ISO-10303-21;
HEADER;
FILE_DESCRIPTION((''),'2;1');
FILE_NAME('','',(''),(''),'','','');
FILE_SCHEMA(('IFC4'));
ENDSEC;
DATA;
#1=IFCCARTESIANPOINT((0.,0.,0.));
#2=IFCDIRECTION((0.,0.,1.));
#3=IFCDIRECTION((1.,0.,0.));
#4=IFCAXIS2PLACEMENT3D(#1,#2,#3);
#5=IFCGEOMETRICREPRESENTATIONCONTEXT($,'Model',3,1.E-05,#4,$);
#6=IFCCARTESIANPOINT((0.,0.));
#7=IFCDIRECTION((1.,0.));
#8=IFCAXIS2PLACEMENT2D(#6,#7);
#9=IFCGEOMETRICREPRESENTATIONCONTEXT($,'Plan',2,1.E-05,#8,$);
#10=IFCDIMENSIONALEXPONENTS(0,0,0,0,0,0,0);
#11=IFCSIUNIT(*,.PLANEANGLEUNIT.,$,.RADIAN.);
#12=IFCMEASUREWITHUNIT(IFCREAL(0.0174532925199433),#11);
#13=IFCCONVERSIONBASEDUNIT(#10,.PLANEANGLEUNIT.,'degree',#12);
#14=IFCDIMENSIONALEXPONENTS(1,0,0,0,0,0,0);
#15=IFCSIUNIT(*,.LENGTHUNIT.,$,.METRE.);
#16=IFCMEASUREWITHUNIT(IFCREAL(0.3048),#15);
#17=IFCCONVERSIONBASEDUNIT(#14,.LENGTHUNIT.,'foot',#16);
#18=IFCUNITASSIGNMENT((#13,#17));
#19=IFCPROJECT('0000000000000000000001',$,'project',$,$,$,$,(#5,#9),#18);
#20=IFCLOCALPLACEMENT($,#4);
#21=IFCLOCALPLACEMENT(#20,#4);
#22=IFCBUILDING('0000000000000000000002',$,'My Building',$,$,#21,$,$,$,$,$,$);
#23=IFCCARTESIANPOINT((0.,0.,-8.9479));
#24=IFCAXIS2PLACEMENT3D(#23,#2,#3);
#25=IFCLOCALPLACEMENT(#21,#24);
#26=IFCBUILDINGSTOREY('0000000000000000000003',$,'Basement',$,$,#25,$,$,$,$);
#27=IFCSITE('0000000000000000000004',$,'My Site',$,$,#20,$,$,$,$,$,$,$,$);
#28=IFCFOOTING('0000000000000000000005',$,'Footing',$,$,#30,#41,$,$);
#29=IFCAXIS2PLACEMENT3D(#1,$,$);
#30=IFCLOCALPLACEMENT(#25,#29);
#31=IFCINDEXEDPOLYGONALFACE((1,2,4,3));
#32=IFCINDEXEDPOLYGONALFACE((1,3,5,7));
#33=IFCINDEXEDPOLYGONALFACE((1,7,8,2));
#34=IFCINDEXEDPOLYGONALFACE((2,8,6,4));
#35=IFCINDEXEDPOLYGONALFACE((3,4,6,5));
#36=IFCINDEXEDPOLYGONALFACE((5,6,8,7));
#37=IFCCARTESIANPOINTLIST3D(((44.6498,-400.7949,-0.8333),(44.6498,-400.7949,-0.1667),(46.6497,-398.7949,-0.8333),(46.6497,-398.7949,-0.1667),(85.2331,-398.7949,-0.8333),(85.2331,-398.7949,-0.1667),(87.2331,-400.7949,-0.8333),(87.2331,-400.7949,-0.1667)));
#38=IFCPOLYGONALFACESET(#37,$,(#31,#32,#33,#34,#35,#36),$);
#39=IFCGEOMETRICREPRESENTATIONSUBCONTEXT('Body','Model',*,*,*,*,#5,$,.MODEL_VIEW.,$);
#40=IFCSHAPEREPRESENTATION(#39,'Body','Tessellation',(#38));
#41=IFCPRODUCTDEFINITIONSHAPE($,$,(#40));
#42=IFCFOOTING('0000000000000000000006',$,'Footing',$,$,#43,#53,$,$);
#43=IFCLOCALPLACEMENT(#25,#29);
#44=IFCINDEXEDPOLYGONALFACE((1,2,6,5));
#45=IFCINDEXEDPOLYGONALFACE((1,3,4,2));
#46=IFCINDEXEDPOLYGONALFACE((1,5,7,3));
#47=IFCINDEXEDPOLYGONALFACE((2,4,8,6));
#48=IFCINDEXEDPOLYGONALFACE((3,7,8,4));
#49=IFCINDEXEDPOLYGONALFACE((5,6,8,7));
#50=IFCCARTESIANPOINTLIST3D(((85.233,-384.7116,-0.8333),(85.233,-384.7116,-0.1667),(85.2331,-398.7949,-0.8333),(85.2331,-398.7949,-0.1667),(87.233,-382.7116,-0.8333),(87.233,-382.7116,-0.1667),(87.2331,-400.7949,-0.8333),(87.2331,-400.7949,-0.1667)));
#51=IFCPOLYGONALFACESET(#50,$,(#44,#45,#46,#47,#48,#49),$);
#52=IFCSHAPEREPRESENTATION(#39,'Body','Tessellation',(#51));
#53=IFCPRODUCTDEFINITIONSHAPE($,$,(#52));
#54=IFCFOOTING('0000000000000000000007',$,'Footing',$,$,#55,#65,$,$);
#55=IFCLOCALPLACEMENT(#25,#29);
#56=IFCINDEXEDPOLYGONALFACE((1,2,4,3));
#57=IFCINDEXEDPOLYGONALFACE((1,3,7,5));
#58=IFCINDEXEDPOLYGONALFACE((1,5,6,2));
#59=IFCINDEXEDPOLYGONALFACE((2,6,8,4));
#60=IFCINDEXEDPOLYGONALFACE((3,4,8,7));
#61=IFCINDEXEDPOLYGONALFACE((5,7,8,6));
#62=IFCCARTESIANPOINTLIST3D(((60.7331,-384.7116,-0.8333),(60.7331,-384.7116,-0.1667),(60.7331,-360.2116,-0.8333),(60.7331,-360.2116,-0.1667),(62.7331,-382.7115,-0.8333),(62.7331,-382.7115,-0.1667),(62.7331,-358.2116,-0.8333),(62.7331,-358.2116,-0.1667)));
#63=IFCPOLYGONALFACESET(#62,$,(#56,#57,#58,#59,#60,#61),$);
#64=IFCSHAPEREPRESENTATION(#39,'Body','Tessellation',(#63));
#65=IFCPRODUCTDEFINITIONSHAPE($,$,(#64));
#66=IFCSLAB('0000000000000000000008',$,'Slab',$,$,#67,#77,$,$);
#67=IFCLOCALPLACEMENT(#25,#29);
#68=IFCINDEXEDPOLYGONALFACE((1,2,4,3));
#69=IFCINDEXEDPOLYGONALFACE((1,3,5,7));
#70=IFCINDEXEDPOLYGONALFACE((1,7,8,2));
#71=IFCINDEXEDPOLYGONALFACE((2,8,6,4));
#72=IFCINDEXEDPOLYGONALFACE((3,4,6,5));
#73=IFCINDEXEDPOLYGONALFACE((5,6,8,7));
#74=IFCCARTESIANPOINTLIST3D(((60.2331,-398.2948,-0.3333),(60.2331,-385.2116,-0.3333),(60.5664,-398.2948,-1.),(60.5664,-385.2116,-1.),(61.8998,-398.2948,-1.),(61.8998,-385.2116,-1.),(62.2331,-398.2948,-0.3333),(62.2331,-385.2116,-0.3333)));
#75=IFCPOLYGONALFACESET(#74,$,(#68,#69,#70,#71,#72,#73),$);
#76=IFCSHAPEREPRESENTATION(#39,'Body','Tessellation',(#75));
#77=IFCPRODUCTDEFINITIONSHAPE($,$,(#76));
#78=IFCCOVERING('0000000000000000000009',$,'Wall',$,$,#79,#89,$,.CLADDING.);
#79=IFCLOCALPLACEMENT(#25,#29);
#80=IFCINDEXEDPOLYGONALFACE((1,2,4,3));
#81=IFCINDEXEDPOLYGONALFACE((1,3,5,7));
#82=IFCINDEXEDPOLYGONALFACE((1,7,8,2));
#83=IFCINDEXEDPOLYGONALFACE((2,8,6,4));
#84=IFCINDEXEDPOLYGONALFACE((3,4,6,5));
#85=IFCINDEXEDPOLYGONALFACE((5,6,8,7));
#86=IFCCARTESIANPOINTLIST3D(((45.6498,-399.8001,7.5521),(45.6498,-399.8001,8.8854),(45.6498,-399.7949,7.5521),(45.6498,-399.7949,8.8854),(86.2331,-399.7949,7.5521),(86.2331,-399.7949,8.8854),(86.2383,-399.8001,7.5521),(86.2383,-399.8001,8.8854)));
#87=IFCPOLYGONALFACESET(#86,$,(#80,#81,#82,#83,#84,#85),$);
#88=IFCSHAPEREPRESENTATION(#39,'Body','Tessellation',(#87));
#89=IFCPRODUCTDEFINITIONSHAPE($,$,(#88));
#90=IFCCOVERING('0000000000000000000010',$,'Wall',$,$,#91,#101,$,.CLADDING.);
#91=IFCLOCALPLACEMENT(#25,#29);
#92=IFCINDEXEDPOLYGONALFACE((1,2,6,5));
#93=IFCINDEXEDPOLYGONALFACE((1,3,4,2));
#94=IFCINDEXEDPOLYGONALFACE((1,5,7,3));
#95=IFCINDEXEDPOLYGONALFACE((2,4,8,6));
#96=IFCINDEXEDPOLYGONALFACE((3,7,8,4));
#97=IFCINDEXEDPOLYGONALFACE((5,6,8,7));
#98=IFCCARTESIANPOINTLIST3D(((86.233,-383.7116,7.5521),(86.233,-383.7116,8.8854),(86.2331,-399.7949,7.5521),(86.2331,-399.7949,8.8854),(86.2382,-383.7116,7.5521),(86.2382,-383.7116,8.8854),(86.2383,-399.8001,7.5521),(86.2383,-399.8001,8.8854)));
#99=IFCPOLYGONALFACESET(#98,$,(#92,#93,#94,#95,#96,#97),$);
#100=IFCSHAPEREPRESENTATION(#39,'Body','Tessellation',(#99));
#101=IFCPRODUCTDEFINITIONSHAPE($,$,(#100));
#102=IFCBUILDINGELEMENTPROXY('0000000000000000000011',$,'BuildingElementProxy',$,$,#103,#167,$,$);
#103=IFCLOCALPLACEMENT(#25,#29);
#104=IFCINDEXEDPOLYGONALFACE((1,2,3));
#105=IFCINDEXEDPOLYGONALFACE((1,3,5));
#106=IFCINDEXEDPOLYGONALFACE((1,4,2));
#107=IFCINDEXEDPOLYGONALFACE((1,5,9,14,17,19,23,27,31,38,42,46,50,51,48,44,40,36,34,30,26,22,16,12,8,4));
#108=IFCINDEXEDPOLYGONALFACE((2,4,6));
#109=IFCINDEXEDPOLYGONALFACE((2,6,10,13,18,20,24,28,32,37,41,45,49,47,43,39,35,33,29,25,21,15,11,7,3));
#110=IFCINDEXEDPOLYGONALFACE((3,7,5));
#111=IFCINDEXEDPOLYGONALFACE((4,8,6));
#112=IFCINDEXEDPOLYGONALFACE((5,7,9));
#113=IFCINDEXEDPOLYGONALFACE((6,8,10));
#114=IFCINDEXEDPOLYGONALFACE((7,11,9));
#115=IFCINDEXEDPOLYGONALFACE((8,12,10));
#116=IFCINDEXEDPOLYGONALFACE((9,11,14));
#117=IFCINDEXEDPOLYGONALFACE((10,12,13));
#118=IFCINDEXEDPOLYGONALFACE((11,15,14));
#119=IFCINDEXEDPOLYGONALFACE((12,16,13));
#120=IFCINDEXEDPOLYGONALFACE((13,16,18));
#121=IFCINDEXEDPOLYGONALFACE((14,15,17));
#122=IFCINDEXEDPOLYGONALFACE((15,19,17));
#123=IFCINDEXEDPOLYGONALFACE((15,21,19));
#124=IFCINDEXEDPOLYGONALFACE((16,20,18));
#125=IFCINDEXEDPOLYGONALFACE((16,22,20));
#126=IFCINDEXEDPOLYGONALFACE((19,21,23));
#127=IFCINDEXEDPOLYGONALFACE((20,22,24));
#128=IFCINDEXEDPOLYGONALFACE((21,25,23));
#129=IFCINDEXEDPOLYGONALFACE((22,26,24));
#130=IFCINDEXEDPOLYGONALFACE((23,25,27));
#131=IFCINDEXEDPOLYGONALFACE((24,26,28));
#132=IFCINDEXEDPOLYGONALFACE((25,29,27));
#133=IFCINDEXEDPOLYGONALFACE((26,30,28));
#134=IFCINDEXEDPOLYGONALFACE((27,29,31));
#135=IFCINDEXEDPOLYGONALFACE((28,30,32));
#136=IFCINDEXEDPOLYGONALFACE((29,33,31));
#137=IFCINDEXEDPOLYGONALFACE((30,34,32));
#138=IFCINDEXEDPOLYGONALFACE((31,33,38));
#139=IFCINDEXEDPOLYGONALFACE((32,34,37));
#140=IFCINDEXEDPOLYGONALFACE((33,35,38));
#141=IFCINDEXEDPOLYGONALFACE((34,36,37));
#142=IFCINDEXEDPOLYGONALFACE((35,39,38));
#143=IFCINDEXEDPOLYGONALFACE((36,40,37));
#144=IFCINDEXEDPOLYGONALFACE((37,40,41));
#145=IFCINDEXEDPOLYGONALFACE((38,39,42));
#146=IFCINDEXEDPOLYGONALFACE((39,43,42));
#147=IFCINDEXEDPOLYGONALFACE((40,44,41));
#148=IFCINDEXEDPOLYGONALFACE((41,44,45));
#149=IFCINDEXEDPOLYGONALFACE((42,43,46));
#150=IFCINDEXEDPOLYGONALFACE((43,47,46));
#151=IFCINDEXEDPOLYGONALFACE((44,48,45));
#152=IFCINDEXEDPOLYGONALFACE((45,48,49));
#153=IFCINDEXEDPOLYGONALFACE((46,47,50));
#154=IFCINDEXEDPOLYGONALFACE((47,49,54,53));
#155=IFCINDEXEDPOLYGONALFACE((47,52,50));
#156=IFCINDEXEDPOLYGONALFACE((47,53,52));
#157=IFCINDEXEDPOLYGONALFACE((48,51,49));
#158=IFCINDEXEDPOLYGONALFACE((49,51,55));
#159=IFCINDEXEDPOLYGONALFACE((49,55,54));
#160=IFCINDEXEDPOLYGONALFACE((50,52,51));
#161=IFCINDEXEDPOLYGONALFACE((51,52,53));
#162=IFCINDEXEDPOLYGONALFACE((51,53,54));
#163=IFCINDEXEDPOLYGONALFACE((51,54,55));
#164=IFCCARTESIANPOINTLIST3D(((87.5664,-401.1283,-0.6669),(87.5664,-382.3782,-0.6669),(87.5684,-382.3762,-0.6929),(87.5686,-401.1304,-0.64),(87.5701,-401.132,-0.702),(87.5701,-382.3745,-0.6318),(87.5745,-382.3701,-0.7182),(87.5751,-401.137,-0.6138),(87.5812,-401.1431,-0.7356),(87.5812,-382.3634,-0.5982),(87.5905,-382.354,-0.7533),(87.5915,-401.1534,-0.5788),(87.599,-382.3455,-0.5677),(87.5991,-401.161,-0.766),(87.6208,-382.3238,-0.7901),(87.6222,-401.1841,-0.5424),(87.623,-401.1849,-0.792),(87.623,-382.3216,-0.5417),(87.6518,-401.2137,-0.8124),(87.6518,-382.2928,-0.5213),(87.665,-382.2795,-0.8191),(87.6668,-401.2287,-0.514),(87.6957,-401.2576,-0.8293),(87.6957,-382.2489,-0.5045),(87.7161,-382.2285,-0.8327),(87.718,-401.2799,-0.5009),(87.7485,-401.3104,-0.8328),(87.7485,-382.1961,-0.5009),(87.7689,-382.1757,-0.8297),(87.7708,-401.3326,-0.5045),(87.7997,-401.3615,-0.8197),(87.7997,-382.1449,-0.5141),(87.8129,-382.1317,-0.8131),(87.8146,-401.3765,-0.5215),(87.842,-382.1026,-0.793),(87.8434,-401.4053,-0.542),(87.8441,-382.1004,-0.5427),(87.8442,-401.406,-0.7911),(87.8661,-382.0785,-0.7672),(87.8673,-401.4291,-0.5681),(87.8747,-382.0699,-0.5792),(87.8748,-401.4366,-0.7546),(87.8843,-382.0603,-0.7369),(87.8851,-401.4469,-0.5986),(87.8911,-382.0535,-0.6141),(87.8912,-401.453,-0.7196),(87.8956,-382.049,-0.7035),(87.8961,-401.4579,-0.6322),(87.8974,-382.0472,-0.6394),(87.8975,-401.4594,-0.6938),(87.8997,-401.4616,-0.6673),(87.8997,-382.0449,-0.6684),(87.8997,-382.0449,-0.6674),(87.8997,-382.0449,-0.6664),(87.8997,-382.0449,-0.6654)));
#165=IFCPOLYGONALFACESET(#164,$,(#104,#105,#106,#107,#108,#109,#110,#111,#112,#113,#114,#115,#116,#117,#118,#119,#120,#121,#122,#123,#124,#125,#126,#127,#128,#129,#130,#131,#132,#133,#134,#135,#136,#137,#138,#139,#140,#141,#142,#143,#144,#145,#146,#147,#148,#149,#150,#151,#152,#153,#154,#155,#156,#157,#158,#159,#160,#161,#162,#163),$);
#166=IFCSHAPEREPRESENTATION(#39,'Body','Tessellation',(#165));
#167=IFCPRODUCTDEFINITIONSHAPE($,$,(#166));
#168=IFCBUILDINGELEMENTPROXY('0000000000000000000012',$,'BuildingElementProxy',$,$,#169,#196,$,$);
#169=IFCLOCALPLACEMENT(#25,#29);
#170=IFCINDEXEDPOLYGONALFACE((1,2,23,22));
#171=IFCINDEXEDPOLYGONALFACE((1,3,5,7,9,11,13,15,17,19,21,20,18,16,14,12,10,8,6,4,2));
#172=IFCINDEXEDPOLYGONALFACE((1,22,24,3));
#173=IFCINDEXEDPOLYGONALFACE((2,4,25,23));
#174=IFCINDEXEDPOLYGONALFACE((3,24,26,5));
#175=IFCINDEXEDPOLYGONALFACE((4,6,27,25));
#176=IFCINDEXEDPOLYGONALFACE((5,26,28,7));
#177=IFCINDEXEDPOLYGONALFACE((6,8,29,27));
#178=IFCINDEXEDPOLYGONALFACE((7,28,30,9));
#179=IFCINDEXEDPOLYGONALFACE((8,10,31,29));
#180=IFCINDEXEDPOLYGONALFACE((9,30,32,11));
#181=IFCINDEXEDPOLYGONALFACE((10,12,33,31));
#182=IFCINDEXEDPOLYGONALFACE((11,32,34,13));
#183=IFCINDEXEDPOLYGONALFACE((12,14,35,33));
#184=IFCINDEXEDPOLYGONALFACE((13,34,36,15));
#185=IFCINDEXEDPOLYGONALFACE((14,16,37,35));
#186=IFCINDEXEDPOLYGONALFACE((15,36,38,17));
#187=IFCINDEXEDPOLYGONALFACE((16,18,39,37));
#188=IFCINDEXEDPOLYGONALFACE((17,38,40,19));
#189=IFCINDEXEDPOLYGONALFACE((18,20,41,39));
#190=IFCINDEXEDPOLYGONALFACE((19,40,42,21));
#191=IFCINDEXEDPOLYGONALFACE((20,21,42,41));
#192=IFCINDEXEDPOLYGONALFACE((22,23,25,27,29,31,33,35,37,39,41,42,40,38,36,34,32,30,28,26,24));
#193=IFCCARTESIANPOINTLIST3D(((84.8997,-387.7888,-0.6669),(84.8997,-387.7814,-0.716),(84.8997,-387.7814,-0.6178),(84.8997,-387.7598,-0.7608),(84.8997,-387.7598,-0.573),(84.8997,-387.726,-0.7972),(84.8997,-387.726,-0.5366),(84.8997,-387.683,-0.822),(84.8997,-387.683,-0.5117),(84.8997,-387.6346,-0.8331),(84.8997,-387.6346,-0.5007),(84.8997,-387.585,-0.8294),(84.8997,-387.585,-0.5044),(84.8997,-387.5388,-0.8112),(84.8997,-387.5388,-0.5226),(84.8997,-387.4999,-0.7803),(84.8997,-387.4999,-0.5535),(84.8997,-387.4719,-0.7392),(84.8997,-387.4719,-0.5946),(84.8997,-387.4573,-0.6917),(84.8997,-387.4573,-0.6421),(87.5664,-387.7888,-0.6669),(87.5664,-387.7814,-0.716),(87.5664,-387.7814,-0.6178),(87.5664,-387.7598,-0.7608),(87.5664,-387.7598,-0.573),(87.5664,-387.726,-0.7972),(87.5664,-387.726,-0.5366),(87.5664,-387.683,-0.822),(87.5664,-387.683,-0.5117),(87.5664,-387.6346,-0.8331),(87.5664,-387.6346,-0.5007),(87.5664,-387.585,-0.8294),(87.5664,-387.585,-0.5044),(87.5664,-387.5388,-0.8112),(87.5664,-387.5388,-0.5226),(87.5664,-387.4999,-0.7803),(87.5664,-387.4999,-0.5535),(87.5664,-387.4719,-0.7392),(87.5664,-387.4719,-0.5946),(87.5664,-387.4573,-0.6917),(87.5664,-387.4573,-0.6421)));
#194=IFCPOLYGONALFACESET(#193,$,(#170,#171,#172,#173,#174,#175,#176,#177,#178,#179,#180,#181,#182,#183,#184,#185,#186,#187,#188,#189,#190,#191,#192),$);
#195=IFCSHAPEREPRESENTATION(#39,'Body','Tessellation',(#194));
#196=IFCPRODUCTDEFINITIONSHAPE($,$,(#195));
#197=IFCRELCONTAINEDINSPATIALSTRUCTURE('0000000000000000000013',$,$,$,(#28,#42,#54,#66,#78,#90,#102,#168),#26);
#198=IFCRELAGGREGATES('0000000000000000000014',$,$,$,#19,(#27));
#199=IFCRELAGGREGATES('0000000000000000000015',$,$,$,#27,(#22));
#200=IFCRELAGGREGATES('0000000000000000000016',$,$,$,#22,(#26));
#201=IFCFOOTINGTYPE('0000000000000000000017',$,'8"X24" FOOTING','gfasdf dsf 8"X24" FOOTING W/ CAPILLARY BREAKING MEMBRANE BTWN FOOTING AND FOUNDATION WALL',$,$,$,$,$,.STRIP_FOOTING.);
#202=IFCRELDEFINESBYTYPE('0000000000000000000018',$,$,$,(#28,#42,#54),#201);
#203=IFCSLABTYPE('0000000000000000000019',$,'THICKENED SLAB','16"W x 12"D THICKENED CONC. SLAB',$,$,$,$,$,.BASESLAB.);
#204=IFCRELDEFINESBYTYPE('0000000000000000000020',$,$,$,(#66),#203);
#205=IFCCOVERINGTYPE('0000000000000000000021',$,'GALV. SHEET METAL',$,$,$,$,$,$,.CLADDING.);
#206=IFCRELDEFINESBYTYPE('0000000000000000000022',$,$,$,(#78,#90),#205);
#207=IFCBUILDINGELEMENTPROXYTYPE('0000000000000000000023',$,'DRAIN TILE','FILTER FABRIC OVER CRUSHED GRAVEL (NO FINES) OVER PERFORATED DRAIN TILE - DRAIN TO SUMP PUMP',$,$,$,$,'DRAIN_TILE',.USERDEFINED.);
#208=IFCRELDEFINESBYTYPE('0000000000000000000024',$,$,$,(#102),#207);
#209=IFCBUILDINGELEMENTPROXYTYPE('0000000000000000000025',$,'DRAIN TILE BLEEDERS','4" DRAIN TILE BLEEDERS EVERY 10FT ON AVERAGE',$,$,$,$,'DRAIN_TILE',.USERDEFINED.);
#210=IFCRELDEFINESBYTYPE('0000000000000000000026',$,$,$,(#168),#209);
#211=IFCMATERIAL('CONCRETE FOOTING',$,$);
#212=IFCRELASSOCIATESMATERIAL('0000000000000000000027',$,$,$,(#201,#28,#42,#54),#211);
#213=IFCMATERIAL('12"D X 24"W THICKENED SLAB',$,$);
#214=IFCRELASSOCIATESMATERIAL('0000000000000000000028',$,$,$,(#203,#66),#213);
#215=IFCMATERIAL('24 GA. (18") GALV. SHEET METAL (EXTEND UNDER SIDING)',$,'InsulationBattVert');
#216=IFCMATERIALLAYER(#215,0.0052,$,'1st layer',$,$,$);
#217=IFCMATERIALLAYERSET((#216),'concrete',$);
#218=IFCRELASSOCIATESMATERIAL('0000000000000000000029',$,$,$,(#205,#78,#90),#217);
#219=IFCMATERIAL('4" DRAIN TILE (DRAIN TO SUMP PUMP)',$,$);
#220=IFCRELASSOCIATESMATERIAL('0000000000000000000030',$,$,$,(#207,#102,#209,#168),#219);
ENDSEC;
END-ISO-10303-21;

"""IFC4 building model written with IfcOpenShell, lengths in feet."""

from ifc_helpers import new_model, entity, si_unit, converted_unit, frame, origin_with_axes, origin_2d_with_axis, place, context, subcontext, project, spatial, line, indexed_curve, rectangle, circle, outline, extrude, clip, halfspace, material, layer, layer_set, layer_usage, material_profile, profile_set, profile_usage, type_object, element, save


model = new_model("IFC4")

# Units and contexts
model_context = context("Model", 3, precision=1e-05, world=origin_with_axes())
plan_context = context("Plan", 2, precision=1e-05, world=origin_2d_with_axis())
body_context = subcontext(model_context, "Body", "Model", "MODEL_VIEW")
ifc_project = project(units=[converted_unit("PLANEANGLEUNIT", "degree", entity("IfcReal", 0.0174532925199433), si_unit("PLANEANGLEUNIT", "RADIAN"), dimensions=[0, 0, 0, 0, 0, 0, 0]), converted_unit("LENGTHUNIT", "foot", entity("IfcReal", 0.3048), si_unit("LENGTHUNIT", "METRE"), dimensions=[1, 0, 0, 0, 0, 0, 0])], contexts=[model_context, plan_context])

# Site, building, storey
site_placement = place(None, origin_with_axes())
site = spatial("IfcSite", under=ifc_project, at=site_placement, Name="My Site")
building_placement = place(site_placement, origin_with_axes())
building = spatial("IfcBuilding", under=site, at=building_placement, Name="My Building")
storey_placement = place(building_placement, frame((0.0, 0.0, -8.9479), z_axis=(0.0, 0.0, 1.0), x_axis=(1.0, 0.0, 0.0)))
storey = spatial("IfcBuildingStorey", under=building, at=storey_placement, Name="Basement")

# Footings
ifc_material_1 = material(Name="CONCRETE FOOTING")
ifc_material_profile_1 = material_profile(ifc_material_1, rectangle(XDim=2.0, YDim=0.6667, kind="CURVE"))
ifc_profile_set_1 = profile_set([ifc_material_profile_1])
ifc_profile_usage_1 = profile_usage(ifc_profile_set_1, cardinal=5)
footing_type = type_object("IfcFootingType", Name="8\"X24\" FOOTING", Description="gfasdf dsf 8\"X24\" FOOTING W/ CAPILLARY BREAKING MEMBRANE BTWN FOOTING AND FOUNDATION WALL", PredefinedType="STRIP_FOOTING", material=ifc_profile_set_1)
footing_1_placement = place(storey_placement, frame((44.6498, -399.7949, -0.5), z_axis=(1.0, 0.0, 0.0), x_axis=(0.0, 1.0, 0.0)))
element("IfcFooting", 1, at=footing_1_placement, inside=storey, type_object=footing_type, material=ifc_profile_usage_1, Name="Footing", context=body_context, shape_type="Clipping", body=[
    clip(clip(extrude(rectangle(XDim=2.0, YDim=0.6667, kind="CURVE"), origin_with_axes(), (0.0, 0.0, 1.0), 42.5833), halfspace(frame((-1.0, 9.4479, 42.5833), z_axis=(0.707106, 0.0, 0.707108), x_axis=(0.0, -1.0, 0.0)), False)), halfspace(frame((-1.0, 9.4479, 0.0), z_axis=(0.707105, 0.0, -0.707109), x_axis=(0.0, -1.0, 0.0)), False)),
])
ifc_profile_usage_2 = profile_usage(ifc_profile_set_1, cardinal=5)
footing_2_placement = place(storey_placement, frame((86.2331, -400.7949, -0.5), z_axis=(-0.000003, 1.0, 0.0), x_axis=(-1.0, -0.000003, 0.0)))
element("IfcFooting", 2, at=footing_2_placement, inside=storey, type_object=footing_type, material=ifc_profile_usage_2, Name="Footing", context=body_context, shape_type="Clipping", body=[
    clip(clip(extrude(rectangle(XDim=2.0, YDim=0.6667, kind="CURVE"), origin_with_axes(), (0.0, 0.0, 1.0), 18.0833), halfspace(frame((-1.0, 9.4479, 18.0833), z_axis=(0.707108, 0.0, 0.707106), x_axis=(0.0, -1.0, 0.0)), False)), halfspace(frame((-1.0, 9.4479, 0.0), z_axis=(0.70711, 0.0, -0.707103), x_axis=(0.0, -1.0, 0.0)), False)),
])
ifc_profile_usage_3 = profile_usage(ifc_profile_set_1, cardinal=5)
footing_3_placement = place(storey_placement, frame((61.7331, -384.7116, -0.5), z_axis=(-0.000001, 1.0, 0.0), x_axis=(-1.0, -0.000001, 0.0)))
element("IfcFooting", 3, at=footing_3_placement, inside=storey, type_object=footing_type, material=ifc_profile_usage_3, Name="Footing", context=body_context, shape_type="Clipping", body=[
    clip(clip(extrude(rectangle(XDim=2.0, YDim=0.6667, kind="CURVE"), origin_with_axes(), (0.0, 0.0, 1.0), 26.5), halfspace(frame((-1.0, 9.4479, 26.5), z_axis=(0.707109, 0.0, 0.707105), x_axis=(0.0, -1.0, 0.0)), False)), halfspace(frame((1.0, 9.4479, 0.0), z_axis=(-0.70711, 0.0, -0.707104), x_axis=(0.0, 1.0, 0.0)), False)),
])

# Slab
ifc_material_2 = material(Name="12\"D X 24\"W THICKENED SLAB")
ifc_material_profile_2 = material_profile(ifc_material_2, outline(indexed_curve([(-1.0, 0.6667), (1.0, 0.6667), (0.6667, 0.0), (-0.6667, 0.0), (-1.0, 0.6667)])))
ifc_profile_set_2 = profile_set([ifc_material_profile_2])
ifc_profile_usage_4 = profile_usage(ifc_profile_set_2, cardinal=5)
slab_type_1 = type_object("IfcSlabType", Name="THICKENED SLAB", Description="16\"W x 12\"D THICKENED CONC. SLAB", PredefinedType="BASESLAB", material=ifc_profile_set_2)
slab_1_placement = place(storey_placement, frame((61.2331, -385.2116, -1.0), z_axis=(0.0, -1.0, 0.0), x_axis=(1.0, 0.0, 0.0)))
element("IfcSlab", 4, at=slab_1_placement, inside=storey, type_object=slab_type_1, material=ifc_profile_usage_4, Name="Slab", context=body_context, shape_type="SweptSolid", body=[
    extrude(outline(indexed_curve([(-1.0, 0.6667), (1.0, 0.6667), (0.6667, 0.0), (-0.6667, 0.0), (-1.0, 0.6667)])), origin_with_axes(), (0.0, 0.0, 1.0), 13.0833),
])

# Coverings
ifc_material_3 = material(Name="24 GA. (18\") GALV. SHEET METAL (EXTEND UNDER SIDING)", Category="InsulationBattVert")
ifc_layer_1 = layer(ifc_material_3, 0.0052, Name="1st layer")
ifc_layer_set_1 = layer_set([ifc_layer_1], Name="concrete")
ifc_layer_usage_1 = layer_usage(ifc_layer_set_1, "AXIS2", "POSITIVE", 0.0)
covering_type_1 = type_object("IfcCoveringType", Name="GALV. SHEET METAL", PredefinedType="CLADDING", material=ifc_layer_set_1)
covering_1_placement = place(storey_placement, frame((45.6498, -399.8001, 7.5521), z_axis=(0.0, 0.0, 1.0), x_axis=(1.0, 0.0, 0.0)))
element("IfcCovering", 5, at=covering_1_placement, inside=storey, type_object=covering_type_1, material=ifc_layer_usage_1, Name="Wall", PredefinedType="CLADDING", context=body_context, shape_type="SweptSolid", body=[
    extrude(outline(indexed_curve([(0.0, 0.0), (0.0, 0.0052), (40.5833, 0.0052), (40.5885, 0.0)], segments=[line(1, 2, 3, 4, 1)])), origin_with_axes(), (0.0, 0.0, 1.0), 1.3333),
])
ifc_layer_usage_2 = layer_usage(ifc_layer_set_1, "AXIS2", "POSITIVE", 0.0)
covering_2_placement = place(storey_placement, frame((86.2383, -399.8001, 7.5521), z_axis=(0.0, 0.0, 1.0), x_axis=(-0.000003, 1.0, 0.0)))
element("IfcCovering", 6, at=covering_2_placement, inside=storey, type_object=covering_type_1, material=ifc_layer_usage_2, Name="Wall", PredefinedType="CLADDING", context=body_context, shape_type="SweptSolid", body=[
    extrude(outline(indexed_curve([(0.0, 0.0), (0.0052, 0.0052), (16.0885, 0.0052), (16.0885, 0.0)], segments=[line(1, 2, 3, 4, 1)])), origin_with_axes(), (0.0, 0.0, 1.0), 1.3333),
])

# Building element proxies
ifc_material_4 = material(Name="4\" DRAIN TILE (DRAIN TO SUMP PUMP)")
ifc_material_profile_3 = material_profile(ifc_material_4, circle(Radius=0.1667, kind="CURVE"), Name="profile name")
ifc_profile_set_3 = profile_set([ifc_material_profile_3], Name="this is name of the profile set")
ifc_profile_usage_5 = profile_usage(ifc_profile_set_3, cardinal=5)
building_element_proxy_type_1 = type_object("IfcBuildingElementProxyType", Name="DRAIN TILE", Description="FILTER FABRIC OVER CRUSHED GRAVEL (NO FINES) OVER PERFORATED DRAIN TILE - DRAIN TO SUMP PUMP", ElementType="DRAIN_TILE", PredefinedType="USERDEFINED", material=ifc_profile_set_3)
proxy_1_placement = place(storey_placement, frame((87.733, -401.4616, -0.6669), z_axis=(-0.000002, 1.0, 0.0), x_axis=(-1.0, -0.000002, 0.0)))
element("IfcBuildingElementProxy", 7, at=proxy_1_placement, inside=storey, type_object=building_element_proxy_type_1, material=ifc_profile_usage_5, Name="BuildingElementProxy", context=body_context, shape_type="Clipping", body=[
    clip(clip(extrude(circle(Radius=0.1667, kind="CURVE"), origin_with_axes(), (0.0, 0.0, 1.0), 19.4167), halfspace(frame((-0.1667, 9.6148, 19.4167), z_axis=(0.707079, 0.0, 0.707134), x_axis=(0.0, -1.0, 0.0)), False)), halfspace(frame((-0.1667, 9.6149, 0.0), z_axis=(0.707081, 0.0, -0.707132), x_axis=(0.0, -1.0, 0.0)), False)),
])
ifc_material_profile_4 = material_profile(ifc_material_4, circle(Radius=0.1667, kind="CURVE"))
ifc_profile_set_4 = profile_set([ifc_material_profile_4])
ifc_profile_usage_6 = profile_usage(ifc_profile_set_4)
building_element_proxy_type_2 = type_object("IfcBuildingElementProxyType", Name="DRAIN TILE BLEEDERS", Description="4\" DRAIN TILE BLEEDERS EVERY 10FT ON AVERAGE", ElementType="DRAIN_TILE", PredefinedType="USERDEFINED", material=ifc_profile_set_4)
proxy_2_placement = place(storey_placement, frame((87.5664, -387.6221, -0.6669), z_axis=(-1.0, -0.000002, 0.0), x_axis=(0.000002, -1.0, 0.0)))
element("IfcBuildingElementProxy", 8, at=proxy_2_placement, inside=storey, type_object=building_element_proxy_type_2, material=ifc_profile_usage_6, Name="BuildingElementProxy", context=body_context, shape_type="SweptSolid", body=[
    extrude(circle(Radius=0.1667, kind="CURVE"), origin_with_axes(), (0.0, 0.0, 1.0), 2.6667),
])

save(model, "model.ifc")
